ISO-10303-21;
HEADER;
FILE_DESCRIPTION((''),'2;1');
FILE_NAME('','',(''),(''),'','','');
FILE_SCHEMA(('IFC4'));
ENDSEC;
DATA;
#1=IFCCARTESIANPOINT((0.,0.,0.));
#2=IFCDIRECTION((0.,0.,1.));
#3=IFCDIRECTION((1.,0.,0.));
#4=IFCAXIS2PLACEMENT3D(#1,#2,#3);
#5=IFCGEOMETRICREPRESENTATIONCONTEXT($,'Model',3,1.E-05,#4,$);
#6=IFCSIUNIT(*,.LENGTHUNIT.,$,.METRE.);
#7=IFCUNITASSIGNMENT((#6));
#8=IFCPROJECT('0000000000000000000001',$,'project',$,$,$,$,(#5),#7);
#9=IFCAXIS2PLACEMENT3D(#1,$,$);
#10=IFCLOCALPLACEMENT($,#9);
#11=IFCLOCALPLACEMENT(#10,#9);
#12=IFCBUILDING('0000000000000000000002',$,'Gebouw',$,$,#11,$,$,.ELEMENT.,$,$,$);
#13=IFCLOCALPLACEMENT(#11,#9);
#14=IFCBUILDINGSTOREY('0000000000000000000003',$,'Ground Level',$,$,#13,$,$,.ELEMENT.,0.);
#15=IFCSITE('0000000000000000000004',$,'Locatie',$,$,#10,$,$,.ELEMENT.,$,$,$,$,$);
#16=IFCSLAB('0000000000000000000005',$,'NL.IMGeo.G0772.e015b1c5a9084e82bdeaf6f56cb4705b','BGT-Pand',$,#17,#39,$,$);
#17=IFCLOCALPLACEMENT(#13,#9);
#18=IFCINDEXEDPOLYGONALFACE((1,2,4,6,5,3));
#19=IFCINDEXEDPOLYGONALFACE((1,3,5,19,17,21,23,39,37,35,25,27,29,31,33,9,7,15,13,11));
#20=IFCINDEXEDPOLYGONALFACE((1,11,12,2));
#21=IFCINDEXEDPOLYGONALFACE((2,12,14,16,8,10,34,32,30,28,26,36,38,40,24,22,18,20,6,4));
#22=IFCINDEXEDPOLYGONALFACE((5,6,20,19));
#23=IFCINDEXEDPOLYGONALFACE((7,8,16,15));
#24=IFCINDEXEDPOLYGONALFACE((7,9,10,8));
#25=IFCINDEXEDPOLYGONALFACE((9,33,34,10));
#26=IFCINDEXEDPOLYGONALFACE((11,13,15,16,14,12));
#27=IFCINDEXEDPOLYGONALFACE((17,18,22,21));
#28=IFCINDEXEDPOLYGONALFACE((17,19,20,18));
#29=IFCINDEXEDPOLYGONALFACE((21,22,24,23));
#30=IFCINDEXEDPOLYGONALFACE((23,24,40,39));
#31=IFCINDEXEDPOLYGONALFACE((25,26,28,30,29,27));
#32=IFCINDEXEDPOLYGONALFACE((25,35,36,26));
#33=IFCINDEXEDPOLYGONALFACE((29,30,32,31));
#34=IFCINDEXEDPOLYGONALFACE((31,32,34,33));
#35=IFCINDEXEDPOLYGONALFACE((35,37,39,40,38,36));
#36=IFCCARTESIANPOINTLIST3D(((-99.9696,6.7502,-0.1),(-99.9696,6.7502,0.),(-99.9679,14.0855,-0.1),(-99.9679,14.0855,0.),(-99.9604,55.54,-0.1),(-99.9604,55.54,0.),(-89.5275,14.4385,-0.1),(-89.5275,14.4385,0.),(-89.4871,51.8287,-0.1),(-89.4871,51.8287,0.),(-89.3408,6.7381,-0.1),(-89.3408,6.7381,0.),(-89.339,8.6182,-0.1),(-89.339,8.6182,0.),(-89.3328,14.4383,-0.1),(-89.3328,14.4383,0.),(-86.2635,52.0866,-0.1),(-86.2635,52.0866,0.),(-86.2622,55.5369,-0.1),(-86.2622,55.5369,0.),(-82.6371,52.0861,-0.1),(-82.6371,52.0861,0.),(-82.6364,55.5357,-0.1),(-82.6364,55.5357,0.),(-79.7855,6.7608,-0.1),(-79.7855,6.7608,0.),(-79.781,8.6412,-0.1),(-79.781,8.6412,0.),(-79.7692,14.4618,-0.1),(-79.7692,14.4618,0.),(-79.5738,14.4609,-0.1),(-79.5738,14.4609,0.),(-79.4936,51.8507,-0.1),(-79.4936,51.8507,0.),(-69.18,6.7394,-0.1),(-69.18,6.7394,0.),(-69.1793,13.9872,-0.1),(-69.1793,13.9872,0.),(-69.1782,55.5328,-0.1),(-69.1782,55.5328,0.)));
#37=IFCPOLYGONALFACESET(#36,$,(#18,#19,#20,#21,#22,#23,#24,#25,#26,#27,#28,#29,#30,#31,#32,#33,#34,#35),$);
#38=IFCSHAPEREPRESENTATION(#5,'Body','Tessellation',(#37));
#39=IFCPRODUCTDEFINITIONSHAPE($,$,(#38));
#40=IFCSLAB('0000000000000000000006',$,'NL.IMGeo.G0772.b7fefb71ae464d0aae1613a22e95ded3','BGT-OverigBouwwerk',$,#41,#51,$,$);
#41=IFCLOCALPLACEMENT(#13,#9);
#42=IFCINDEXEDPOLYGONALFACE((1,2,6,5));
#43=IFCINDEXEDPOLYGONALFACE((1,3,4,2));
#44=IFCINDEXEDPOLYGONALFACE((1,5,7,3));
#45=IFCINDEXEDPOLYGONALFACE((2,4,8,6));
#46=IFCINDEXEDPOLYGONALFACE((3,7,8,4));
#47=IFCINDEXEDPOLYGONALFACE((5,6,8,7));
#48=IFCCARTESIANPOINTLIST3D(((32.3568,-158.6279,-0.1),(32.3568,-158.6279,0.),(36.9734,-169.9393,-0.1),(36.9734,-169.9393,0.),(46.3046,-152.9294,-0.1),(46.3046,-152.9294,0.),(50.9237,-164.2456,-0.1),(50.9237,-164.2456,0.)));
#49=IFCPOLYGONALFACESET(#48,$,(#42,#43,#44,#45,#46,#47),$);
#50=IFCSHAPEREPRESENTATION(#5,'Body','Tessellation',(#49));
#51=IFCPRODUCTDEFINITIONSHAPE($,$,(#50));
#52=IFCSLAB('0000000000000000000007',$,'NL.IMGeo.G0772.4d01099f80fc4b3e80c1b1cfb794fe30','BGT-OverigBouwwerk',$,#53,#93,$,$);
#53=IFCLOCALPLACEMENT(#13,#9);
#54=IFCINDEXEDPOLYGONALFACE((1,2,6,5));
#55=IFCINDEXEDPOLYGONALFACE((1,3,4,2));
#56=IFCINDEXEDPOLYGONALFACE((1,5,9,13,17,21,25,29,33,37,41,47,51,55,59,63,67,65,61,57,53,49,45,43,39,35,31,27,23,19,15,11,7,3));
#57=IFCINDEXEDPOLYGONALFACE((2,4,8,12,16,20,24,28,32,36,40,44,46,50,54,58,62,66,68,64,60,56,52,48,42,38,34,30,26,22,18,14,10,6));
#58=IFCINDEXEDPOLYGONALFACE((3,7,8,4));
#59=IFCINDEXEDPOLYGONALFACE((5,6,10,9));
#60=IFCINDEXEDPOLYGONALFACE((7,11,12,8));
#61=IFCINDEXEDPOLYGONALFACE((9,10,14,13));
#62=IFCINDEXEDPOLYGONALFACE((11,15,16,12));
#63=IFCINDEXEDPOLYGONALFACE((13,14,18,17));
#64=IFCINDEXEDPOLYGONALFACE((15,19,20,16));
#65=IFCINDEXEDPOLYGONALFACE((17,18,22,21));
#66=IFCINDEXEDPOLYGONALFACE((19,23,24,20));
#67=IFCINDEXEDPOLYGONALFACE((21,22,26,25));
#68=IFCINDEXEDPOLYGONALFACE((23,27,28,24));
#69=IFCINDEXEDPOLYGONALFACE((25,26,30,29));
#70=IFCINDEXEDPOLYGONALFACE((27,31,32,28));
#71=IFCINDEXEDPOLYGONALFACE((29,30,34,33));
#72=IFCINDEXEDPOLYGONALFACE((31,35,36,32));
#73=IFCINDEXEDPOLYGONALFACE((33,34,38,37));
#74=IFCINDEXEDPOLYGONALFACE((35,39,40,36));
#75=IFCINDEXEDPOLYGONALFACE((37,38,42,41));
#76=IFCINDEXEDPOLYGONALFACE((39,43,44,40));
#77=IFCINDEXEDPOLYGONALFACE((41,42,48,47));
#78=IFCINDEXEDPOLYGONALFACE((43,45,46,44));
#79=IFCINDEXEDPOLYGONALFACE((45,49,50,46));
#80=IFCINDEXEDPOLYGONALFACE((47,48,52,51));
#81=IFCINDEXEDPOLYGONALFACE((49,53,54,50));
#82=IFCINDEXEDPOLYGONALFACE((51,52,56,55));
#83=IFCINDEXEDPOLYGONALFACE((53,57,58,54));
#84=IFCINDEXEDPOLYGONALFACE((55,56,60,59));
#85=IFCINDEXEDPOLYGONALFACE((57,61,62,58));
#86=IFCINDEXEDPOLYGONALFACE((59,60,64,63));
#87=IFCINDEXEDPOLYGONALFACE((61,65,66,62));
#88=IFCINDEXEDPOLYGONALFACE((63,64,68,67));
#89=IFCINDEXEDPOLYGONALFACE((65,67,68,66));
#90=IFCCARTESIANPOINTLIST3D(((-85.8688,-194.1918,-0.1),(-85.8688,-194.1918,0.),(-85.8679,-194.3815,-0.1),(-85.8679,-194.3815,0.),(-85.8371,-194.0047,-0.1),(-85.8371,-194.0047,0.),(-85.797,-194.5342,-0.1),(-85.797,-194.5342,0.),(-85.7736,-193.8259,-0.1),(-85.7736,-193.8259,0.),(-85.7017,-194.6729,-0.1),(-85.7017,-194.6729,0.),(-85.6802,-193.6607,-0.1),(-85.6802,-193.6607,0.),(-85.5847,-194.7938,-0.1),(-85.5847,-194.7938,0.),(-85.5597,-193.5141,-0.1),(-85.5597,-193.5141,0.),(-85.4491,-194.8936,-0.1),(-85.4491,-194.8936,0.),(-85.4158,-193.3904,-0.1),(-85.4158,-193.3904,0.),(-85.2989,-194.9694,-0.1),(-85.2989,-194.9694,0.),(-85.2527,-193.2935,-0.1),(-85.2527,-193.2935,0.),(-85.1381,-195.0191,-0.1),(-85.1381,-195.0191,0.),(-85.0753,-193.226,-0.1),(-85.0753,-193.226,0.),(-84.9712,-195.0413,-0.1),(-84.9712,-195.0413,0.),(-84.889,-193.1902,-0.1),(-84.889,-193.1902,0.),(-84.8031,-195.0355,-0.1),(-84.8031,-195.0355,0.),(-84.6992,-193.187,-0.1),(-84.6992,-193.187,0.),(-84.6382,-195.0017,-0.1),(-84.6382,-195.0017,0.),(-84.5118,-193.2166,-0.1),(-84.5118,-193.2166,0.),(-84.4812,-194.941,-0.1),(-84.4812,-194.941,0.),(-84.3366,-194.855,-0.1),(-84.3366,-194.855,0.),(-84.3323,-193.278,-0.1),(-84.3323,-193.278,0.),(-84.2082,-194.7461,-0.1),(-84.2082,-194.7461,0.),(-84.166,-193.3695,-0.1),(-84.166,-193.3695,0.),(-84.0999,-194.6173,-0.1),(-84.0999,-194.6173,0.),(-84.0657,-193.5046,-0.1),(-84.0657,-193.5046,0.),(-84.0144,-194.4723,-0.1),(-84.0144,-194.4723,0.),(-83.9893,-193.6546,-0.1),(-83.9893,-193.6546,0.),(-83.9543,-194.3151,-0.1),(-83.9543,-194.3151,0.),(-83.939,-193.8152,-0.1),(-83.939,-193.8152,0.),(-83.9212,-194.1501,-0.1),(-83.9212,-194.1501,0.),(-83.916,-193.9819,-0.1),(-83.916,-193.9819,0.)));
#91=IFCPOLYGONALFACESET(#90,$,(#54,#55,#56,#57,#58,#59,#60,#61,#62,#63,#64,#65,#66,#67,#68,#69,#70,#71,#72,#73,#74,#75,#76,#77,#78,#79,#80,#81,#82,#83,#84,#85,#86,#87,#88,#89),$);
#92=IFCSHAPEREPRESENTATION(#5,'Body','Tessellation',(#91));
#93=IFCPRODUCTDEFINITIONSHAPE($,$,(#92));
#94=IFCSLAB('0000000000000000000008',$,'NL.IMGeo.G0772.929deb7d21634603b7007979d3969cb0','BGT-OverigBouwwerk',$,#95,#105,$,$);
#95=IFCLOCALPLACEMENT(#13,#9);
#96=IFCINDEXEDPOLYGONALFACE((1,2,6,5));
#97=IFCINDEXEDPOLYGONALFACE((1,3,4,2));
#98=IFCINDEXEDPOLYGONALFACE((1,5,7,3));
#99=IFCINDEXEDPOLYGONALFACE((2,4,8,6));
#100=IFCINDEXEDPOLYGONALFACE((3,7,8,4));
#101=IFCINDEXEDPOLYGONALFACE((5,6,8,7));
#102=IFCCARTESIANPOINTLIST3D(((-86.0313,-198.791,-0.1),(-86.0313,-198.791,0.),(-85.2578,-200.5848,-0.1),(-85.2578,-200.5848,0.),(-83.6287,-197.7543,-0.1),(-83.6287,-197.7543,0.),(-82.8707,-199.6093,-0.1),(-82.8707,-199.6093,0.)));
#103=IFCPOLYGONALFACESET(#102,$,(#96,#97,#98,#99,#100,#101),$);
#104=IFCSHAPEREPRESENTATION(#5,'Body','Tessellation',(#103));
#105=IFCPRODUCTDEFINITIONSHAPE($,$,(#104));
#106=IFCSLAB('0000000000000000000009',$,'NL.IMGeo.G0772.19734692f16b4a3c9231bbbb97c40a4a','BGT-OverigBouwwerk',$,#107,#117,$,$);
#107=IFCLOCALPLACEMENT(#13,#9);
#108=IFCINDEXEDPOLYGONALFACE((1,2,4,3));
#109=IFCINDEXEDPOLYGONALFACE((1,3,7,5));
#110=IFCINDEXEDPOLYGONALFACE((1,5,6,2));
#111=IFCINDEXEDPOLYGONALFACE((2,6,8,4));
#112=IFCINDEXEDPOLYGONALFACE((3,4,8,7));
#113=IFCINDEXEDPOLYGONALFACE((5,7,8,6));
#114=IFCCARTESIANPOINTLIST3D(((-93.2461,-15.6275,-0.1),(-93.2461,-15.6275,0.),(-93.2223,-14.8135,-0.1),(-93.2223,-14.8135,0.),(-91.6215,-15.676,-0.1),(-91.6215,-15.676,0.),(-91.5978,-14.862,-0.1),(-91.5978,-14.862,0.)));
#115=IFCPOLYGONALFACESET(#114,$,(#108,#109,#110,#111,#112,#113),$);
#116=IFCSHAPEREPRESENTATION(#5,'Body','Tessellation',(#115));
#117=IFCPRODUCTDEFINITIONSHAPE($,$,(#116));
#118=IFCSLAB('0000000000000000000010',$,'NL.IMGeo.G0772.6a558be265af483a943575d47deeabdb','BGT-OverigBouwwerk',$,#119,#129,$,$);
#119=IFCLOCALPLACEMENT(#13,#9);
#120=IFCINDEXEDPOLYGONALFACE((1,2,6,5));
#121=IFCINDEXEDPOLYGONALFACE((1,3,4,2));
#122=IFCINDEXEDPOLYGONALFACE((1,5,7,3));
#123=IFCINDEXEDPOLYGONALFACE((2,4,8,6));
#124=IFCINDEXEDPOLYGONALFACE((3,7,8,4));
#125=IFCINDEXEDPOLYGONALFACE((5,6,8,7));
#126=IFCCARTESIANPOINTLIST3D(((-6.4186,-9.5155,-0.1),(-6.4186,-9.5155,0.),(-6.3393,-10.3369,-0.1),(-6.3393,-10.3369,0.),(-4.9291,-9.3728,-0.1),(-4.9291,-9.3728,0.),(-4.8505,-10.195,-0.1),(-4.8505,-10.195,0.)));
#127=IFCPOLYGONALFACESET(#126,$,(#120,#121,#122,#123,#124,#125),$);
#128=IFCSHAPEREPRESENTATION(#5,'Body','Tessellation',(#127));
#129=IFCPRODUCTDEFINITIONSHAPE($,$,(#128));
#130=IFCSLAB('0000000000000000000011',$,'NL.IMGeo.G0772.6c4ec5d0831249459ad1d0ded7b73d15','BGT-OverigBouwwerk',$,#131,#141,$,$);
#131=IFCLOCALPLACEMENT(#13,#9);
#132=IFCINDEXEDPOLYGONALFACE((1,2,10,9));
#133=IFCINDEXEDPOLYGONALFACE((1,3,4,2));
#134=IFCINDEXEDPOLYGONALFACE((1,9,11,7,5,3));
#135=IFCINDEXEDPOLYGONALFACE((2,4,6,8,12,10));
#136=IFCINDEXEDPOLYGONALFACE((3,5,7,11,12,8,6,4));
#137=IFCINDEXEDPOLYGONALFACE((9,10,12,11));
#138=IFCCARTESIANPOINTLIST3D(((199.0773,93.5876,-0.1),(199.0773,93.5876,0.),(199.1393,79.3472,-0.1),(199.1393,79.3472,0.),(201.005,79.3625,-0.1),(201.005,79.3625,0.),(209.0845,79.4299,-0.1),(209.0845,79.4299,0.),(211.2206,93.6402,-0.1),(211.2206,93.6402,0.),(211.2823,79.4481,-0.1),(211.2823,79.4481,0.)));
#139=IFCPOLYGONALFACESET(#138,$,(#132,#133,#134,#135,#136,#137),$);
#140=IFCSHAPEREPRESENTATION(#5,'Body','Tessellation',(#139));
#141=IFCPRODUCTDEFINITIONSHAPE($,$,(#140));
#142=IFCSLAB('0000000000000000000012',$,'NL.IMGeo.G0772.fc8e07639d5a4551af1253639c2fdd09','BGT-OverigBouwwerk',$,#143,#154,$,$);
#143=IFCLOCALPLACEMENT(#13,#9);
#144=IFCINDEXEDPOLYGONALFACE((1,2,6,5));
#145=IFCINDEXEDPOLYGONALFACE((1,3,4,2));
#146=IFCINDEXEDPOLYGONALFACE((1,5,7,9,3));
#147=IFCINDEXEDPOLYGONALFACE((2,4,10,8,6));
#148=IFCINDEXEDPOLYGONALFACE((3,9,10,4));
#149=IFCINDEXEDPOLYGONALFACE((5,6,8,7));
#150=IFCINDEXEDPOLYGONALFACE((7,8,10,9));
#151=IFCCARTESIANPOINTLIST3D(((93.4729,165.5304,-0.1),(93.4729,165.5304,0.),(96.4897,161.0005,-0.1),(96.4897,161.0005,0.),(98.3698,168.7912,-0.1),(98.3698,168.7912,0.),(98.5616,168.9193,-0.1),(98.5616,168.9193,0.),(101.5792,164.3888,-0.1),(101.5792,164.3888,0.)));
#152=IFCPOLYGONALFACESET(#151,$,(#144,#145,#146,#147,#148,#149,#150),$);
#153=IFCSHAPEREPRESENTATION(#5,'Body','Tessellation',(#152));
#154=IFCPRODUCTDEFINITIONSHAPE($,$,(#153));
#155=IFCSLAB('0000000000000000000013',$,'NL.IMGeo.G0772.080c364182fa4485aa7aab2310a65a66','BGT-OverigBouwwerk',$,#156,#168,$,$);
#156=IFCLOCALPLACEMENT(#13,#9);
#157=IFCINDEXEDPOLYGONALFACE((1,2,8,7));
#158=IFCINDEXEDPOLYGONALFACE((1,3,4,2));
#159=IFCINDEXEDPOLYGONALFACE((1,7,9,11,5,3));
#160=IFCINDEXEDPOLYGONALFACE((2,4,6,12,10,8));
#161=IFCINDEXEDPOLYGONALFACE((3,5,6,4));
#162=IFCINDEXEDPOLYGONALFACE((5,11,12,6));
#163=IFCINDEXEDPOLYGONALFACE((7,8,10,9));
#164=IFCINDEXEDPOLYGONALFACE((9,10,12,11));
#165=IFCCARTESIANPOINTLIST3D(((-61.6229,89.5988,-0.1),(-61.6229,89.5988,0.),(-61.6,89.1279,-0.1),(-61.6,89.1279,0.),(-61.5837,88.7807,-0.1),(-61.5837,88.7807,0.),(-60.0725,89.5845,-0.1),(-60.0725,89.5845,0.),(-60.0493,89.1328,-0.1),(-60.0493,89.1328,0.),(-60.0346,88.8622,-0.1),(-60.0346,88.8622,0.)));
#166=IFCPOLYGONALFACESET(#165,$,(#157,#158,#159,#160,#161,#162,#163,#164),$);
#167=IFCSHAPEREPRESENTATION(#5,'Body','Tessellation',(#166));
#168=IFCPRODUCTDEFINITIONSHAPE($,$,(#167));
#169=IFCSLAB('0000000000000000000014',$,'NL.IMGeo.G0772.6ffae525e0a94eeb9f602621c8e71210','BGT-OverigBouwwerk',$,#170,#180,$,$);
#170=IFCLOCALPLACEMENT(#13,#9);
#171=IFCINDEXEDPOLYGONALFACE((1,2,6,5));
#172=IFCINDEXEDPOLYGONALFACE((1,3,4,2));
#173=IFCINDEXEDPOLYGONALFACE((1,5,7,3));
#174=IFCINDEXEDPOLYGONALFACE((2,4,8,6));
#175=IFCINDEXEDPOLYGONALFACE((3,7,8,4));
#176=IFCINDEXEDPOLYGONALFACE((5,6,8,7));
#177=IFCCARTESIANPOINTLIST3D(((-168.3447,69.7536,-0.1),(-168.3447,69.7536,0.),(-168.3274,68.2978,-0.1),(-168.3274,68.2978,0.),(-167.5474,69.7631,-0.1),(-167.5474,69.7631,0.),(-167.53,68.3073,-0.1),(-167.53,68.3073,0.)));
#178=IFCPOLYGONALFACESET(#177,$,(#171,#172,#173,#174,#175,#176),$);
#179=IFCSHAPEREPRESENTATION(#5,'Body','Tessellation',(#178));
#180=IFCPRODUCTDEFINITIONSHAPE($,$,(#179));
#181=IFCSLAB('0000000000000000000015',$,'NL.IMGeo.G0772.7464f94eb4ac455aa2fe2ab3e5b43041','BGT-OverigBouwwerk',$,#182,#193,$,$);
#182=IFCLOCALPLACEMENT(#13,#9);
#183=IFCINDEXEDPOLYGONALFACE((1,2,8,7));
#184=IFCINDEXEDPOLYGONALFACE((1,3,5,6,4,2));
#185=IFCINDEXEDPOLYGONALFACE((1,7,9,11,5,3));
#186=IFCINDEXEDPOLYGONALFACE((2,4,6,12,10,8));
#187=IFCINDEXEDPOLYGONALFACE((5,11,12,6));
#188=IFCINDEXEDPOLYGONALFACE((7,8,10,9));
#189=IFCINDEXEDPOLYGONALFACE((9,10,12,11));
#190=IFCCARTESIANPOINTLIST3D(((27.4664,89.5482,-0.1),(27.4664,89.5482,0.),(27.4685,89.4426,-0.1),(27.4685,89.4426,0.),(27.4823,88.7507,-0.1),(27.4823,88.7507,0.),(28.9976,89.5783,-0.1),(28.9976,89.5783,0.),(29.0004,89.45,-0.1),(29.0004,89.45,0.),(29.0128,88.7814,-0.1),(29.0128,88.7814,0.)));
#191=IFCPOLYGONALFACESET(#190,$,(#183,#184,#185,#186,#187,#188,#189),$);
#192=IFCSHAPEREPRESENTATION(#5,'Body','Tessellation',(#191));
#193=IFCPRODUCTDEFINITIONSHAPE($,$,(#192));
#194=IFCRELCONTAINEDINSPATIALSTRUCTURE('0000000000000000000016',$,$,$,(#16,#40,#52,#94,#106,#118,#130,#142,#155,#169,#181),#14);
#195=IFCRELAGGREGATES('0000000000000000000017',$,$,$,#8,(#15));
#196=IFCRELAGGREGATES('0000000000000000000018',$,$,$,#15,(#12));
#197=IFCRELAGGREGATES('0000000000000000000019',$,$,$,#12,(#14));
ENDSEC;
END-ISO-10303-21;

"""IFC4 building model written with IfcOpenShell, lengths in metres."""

from ifc_helpers import new_model, si_unit, frame, origin, origin_with_axes, place, context, project, spatial, polyline, outline, extrude, element, save


model = new_model("IFC4")

# Units and contexts
model_context = context("Model", 3, precision=1e-05, world=origin_with_axes())
ifc_project = project(units=[si_unit("LENGTHUNIT", "METRE")], contexts=[model_context])

# Site, building, storey
site_placement = place(None, origin())
site = spatial("IfcSite", under=ifc_project, at=site_placement, Name="Locatie", CompositionType="ELEMENT")
building_placement = place(site_placement, origin())
building = spatial("IfcBuilding", under=site, at=building_placement, Name="Gebouw", CompositionType="ELEMENT")
storey_placement = place(building_placement, origin())
storey = spatial("IfcBuildingStorey", under=building, at=storey_placement, Name="Ground Level", CompositionType="ELEMENT", Elevation=0.0)

# Slabs
slab_1_placement = place(storey_placement, origin())
element("IfcSlab", 1, at=slab_1_placement, inside=storey, Name="NL.IMGeo.G0772.e015b1c5a9084e82bdeaf6f56cb4705b", Description="BGT-Pand", context=model_context, shape_type="SweptSolid", body=[
    extrude(outline(polyline([(-82.6371, 52.0861), (-82.6364, 55.5357), (-69.1782, 55.5328), (-69.1793, 13.9872), (-69.18, 6.7394), (-79.7855, 6.7608), (-79.781, 8.6412), (-79.7692, 14.4618), (-79.5738, 14.4609), (-79.4936, 51.8507), (-89.4871, 51.8287), (-89.5275, 14.4385), (-89.3328, 14.4383), (-89.339, 8.6182), (-89.3408, 6.7381), (-99.9696, 6.7502), (-99.9679, 14.0855), (-99.9604, 55.54), (-86.2622, 55.5369), (-86.2635, 52.0866), (-82.6371, 52.0861)])), frame((0.0, 0.0, -0.1), z_axis=(0.0, 0.0, 1.0), x_axis=(1.0, 0.0, 0.0)), (0.0, 0.0, 1.0), 0.1),
])
slab_2_placement = place(storey_placement, origin())
element("IfcSlab", 2, at=slab_2_placement, inside=storey, Name="NL.IMGeo.G0772.b7fefb71ae464d0aae1613a22e95ded3", Description="BGT-OverigBouwwerk", context=model_context, shape_type="SweptSolid", body=[
    extrude(outline(polyline([(32.3568, -158.6279), (46.3046, -152.9294), (50.9237, -164.2456), (36.9734, -169.9393), (32.3568, -158.6279)])), frame((0.0, 0.0, -0.1), z_axis=(0.0, 0.0, 1.0), x_axis=(1.0, 0.0, 0.0)), (0.0, 0.0, 1.0), 0.1),
])
slab_3_placement = place(storey_placement, origin())
element("IfcSlab", 3, at=slab_3_placement, inside=storey, Name="NL.IMGeo.G0772.4d01099f80fc4b3e80c1b1cfb794fe30", Description="BGT-OverigBouwwerk", context=model_context, shape_type="SweptSolid", body=[
    extrude(outline(polyline([(-85.8688, -194.1918), (-85.8371, -194.0047), (-85.7736, -193.8259), (-85.6802, -193.6607), (-85.5597, -193.5141), (-85.4158, -193.3904), (-85.2527, -193.2935), (-85.0753, -193.226), (-84.889, -193.1902), (-84.6992, -193.187), (-84.5118, -193.2166), (-84.3323, -193.278), (-84.166, -193.3695), (-84.0657, -193.5046), (-83.9893, -193.6546), (-83.939, -193.8152), (-83.916, -193.9819), (-83.9212, -194.1501), (-83.9543, -194.3151), (-84.0144, -194.4723), (-84.0999, -194.6173), (-84.2082, -194.7461), (-84.3366, -194.855), (-84.4812, -194.941), (-84.6382, -195.0017), (-84.8031, -195.0355), (-84.9712, -195.0413), (-85.1381, -195.0191), (-85.2989, -194.9694), (-85.4491, -194.8936), (-85.5847, -194.7938), (-85.7017, -194.6729), (-85.797, -194.5342), (-85.8679, -194.3815), (-85.8688, -194.1918)])), frame((0.0, 0.0, -0.1), z_axis=(0.0, 0.0, 1.0), x_axis=(1.0, 0.0, 0.0)), (0.0, 0.0, 1.0), 0.1),
])
slab_4_placement = place(storey_placement, origin())
element("IfcSlab", 4, at=slab_4_placement, inside=storey, Name="NL.IMGeo.G0772.929deb7d21634603b7007979d3969cb0", Description="BGT-OverigBouwwerk", context=model_context, shape_type="SweptSolid", body=[
    extrude(outline(polyline([(-85.2578, -200.5848), (-86.0313, -198.791), (-83.6287, -197.7543), (-82.8707, -199.6093), (-85.2578, -200.5848)])), frame((0.0, 0.0, -0.1), z_axis=(0.0, 0.0, 1.0), x_axis=(1.0, 0.0, 0.0)), (0.0, 0.0, 1.0), 0.1),
])
slab_5_placement = place(storey_placement, origin())
element("IfcSlab", 5, at=slab_5_placement, inside=storey, Name="NL.IMGeo.G0772.19734692f16b4a3c9231bbbb97c40a4a", Description="BGT-OverigBouwwerk", context=model_context, shape_type="SweptSolid", body=[
    extrude(outline(polyline([(-91.5978, -14.862), (-91.6215, -15.676), (-93.2461, -15.6275), (-93.2223, -14.8135), (-91.5978, -14.862)])), frame((0.0, 0.0, -0.1), z_axis=(0.0, 0.0, 1.0), x_axis=(1.0, 0.0, 0.0)), (0.0, 0.0, 1.0), 0.1),
])
slab_6_placement = place(storey_placement, origin())
element("IfcSlab", 6, at=slab_6_placement, inside=storey, Name="NL.IMGeo.G0772.6a558be265af483a943575d47deeabdb", Description="BGT-OverigBouwwerk", context=model_context, shape_type="SweptSolid", body=[
    extrude(outline(polyline([(-6.3393, -10.3369), (-6.4186, -9.5155), (-4.9291, -9.3728), (-4.8505, -10.195), (-6.3393, -10.3369)])), frame((0.0, 0.0, -0.1), z_axis=(0.0, 0.0, 1.0), x_axis=(1.0, 0.0, 0.0)), (0.0, 0.0, 1.0), 0.1),
])
slab_7_placement = place(storey_placement, origin())
element("IfcSlab", 7, at=slab_7_placement, inside=storey, Name="NL.IMGeo.G0772.6c4ec5d0831249459ad1d0ded7b73d15", Description="BGT-OverigBouwwerk", context=model_context, shape_type="SweptSolid", body=[
    extrude(outline(polyline([(211.2823, 79.4481), (209.0845, 79.4299), (201.005, 79.3625), (199.1393, 79.3472), (199.0773, 93.5876), (211.2206, 93.6402), (211.2823, 79.4481)])), frame((0.0, 0.0, -0.1), z_axis=(0.0, 0.0, 1.0), x_axis=(1.0, 0.0, 0.0)), (0.0, 0.0, 1.0), 0.1),
])
slab_8_placement = place(storey_placement, origin())
element("IfcSlab", 8, at=slab_8_placement, inside=storey, Name="NL.IMGeo.G0772.fc8e07639d5a4551af1253639c2fdd09", Description="BGT-OverigBouwwerk", context=model_context, shape_type="SweptSolid", body=[
    extrude(outline(polyline([(98.3698, 168.7912), (98.5616, 168.9193), (101.5792, 164.3888), (96.4897, 161.0005), (93.4729, 165.5304), (98.3698, 168.7912)])), frame((0.0, 0.0, -0.1), z_axis=(0.0, 0.0, 1.0), x_axis=(1.0, 0.0, 0.0)), (0.0, 0.0, 1.0), 0.1),
])
slab_9_placement = place(storey_placement, origin())
element("IfcSlab", 9, at=slab_9_placement, inside=storey, Name="NL.IMGeo.G0772.080c364182fa4485aa7aab2310a65a66", Description="BGT-OverigBouwwerk", context=model_context, shape_type="SweptSolid", body=[
    extrude(outline(polyline([(-61.6229, 89.5988), (-60.0725, 89.5845), (-60.0493, 89.1328), (-60.0346, 88.8622), (-61.5837, 88.7807), (-61.6, 89.1279), (-61.6229, 89.5988)])), frame((0.0, 0.0, -0.1), z_axis=(0.0, 0.0, 1.0), x_axis=(1.0, 0.0, 0.0)), (0.0, 0.0, 1.0), 0.1),
])
slab_10_placement = place(storey_placement, origin())
element("IfcSlab", 10, at=slab_10_placement, inside=storey, Name="NL.IMGeo.G0772.6ffae525e0a94eeb9f602621c8e71210", Description="BGT-OverigBouwwerk", context=model_context, shape_type="SweptSolid", body=[
    extrude(outline(polyline([(-167.53, 68.3073), (-168.3274, 68.2978), (-168.3447, 69.7536), (-167.5474, 69.7631), (-167.53, 68.3073)])), frame((0.0, 0.0, -0.1), z_axis=(0.0, 0.0, 1.0), x_axis=(1.0, 0.0, 0.0)), (0.0, 0.0, 1.0), 0.1),
])
slab_11_placement = place(storey_placement, origin())
element("IfcSlab", 11, at=slab_11_placement, inside=storey, Name="NL.IMGeo.G0772.7464f94eb4ac455aa2fe2ab3e5b43041", Description="BGT-OverigBouwwerk", context=model_context, shape_type="SweptSolid", body=[
    extrude(outline(polyline([(27.4664, 89.5482), (28.9976, 89.5783), (29.0004, 89.45), (29.0128, 88.7814), (27.4823, 88.7507), (27.4685, 89.4426), (27.4664, 89.5482)])), frame((0.0, 0.0, -0.1), z_axis=(0.0, 0.0, 1.0), x_axis=(1.0, 0.0, 0.0)), (0.0, 0.0, 1.0), 0.1),
])

save(model, "model.ifc")
